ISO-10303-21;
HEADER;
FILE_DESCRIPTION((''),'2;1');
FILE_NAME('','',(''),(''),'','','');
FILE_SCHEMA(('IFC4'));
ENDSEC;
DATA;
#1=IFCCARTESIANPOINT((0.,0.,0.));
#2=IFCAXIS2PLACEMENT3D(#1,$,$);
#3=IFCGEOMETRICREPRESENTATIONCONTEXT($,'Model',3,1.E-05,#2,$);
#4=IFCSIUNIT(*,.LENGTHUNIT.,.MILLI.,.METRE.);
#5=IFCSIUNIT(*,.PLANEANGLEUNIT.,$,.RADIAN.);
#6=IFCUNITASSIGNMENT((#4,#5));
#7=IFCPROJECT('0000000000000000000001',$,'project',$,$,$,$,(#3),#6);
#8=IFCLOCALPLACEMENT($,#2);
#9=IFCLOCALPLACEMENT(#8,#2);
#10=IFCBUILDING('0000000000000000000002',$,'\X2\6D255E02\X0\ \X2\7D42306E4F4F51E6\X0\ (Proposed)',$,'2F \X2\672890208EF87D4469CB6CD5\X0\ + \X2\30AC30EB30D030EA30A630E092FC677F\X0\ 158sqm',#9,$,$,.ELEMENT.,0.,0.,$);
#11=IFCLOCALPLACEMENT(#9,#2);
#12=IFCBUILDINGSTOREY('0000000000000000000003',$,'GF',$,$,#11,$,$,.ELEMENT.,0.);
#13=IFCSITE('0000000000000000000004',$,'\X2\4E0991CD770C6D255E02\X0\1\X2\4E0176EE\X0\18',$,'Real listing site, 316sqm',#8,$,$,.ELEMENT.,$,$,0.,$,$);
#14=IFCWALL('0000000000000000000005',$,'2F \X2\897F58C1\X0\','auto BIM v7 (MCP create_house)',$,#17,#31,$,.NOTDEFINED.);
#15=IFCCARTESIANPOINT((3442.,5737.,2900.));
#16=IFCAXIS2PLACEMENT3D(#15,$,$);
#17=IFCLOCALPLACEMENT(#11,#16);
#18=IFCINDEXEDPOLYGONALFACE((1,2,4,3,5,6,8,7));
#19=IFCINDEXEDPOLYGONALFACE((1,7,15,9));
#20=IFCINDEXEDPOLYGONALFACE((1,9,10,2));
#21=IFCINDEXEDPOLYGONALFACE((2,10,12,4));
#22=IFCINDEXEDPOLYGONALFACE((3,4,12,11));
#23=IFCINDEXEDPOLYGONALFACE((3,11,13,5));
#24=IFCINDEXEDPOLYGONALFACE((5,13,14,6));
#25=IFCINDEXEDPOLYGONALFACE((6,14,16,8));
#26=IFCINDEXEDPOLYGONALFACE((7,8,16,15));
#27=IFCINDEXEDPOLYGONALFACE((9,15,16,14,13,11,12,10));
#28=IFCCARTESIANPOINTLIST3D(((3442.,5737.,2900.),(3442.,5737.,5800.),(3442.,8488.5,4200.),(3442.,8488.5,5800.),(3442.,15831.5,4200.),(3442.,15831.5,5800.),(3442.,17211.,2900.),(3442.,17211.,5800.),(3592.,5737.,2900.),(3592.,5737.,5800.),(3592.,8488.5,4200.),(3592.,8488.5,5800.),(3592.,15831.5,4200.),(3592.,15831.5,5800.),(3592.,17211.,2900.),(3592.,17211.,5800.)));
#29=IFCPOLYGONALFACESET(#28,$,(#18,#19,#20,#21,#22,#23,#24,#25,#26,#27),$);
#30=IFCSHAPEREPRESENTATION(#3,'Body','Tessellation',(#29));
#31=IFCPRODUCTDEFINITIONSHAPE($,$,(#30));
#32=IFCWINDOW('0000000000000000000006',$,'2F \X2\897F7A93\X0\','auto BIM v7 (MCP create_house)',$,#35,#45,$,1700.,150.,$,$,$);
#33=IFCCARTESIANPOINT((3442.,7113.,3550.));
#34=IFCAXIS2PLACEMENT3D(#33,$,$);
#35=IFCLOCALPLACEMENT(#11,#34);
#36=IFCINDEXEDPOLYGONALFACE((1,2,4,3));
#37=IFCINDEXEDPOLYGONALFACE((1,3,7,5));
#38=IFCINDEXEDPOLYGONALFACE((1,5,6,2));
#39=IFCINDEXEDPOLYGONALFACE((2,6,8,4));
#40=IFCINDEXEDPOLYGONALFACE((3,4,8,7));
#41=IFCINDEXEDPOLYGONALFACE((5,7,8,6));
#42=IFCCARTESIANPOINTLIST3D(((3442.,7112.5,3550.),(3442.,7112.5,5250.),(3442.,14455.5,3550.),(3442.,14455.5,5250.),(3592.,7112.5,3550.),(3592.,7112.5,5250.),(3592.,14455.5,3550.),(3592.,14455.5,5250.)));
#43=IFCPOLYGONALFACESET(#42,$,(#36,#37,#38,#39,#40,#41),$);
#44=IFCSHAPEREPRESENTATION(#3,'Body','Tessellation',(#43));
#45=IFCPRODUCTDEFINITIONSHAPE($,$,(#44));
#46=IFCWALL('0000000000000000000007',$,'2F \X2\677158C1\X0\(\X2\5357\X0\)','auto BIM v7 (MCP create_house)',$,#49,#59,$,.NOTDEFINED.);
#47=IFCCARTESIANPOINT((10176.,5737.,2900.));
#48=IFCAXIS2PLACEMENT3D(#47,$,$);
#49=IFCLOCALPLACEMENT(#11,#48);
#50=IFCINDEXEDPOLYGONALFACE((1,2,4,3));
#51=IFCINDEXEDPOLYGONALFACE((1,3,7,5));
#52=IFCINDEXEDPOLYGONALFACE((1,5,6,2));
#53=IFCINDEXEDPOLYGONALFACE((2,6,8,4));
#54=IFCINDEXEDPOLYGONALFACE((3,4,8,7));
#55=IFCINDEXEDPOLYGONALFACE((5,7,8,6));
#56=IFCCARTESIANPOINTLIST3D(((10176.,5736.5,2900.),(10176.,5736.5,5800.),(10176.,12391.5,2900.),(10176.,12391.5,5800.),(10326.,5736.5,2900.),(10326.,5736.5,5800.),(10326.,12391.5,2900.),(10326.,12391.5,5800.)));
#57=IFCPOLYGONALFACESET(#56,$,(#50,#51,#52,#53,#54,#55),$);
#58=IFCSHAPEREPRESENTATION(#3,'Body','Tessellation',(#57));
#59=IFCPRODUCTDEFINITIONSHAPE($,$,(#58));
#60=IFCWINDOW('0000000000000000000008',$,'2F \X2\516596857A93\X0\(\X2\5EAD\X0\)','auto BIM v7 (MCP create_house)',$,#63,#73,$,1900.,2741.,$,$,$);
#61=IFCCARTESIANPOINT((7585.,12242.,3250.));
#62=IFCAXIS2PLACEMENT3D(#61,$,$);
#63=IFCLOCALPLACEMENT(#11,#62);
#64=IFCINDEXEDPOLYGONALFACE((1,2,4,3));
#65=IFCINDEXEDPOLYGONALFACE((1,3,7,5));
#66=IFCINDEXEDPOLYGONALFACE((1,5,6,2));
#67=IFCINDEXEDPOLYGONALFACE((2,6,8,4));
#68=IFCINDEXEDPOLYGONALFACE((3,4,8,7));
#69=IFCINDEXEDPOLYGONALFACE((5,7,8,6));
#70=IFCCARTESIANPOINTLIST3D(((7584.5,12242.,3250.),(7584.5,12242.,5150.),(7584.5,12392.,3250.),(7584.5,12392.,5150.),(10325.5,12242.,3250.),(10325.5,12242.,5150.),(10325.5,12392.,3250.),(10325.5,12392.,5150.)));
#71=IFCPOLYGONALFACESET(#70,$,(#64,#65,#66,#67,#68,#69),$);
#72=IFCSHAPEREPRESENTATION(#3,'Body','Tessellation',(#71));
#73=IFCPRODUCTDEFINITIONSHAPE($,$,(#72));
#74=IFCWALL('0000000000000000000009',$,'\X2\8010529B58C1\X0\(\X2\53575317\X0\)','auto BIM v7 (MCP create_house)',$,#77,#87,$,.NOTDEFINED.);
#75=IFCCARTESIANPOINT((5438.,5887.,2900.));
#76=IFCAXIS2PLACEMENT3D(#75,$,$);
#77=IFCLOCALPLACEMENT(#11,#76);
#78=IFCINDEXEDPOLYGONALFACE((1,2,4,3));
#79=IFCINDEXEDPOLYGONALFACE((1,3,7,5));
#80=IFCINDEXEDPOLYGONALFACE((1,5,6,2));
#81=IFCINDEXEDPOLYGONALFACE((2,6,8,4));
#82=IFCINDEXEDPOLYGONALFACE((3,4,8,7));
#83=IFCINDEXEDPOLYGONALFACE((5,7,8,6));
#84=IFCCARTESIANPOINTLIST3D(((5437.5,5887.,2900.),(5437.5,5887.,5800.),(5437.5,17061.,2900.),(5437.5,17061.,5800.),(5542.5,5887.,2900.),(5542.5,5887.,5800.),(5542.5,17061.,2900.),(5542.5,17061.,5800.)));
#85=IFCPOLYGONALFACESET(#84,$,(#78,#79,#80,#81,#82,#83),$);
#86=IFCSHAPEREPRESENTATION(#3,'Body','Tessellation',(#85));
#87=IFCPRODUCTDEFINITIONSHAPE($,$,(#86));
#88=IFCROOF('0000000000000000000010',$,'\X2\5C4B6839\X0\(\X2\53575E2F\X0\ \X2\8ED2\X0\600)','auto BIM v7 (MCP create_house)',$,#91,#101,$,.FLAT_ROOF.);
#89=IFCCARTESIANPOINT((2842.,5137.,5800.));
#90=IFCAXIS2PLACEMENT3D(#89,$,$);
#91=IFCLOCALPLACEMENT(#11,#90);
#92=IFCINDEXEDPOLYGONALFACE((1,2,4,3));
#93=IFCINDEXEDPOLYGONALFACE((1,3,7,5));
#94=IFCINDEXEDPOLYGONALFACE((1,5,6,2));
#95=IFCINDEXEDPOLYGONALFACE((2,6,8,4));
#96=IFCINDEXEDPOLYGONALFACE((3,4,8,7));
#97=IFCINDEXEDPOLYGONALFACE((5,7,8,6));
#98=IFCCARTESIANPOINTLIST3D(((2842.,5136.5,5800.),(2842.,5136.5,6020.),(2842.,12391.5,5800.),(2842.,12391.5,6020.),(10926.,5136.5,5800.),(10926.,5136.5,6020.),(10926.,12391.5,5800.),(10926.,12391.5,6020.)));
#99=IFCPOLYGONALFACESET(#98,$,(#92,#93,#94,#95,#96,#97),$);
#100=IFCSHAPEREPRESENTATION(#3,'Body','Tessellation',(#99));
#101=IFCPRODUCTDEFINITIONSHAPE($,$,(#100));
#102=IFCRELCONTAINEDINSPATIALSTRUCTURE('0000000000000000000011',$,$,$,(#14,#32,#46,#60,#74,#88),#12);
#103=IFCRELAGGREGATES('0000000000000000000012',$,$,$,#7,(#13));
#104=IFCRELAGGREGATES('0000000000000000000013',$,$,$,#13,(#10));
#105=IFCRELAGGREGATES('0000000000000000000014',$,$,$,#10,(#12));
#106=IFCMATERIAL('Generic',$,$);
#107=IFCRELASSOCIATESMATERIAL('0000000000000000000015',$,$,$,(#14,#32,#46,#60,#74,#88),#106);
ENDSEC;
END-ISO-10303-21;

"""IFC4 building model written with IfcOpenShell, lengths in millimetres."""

from ifc_helpers import new_model, si_unit, frame, frame_2d, origin, place, context, project, spatial, rectangle, extrude, material, element, fill, save


model = new_model("IFC4")

# Units and contexts
model_context = context("Model", 3, precision=1e-05, world=origin())
ifc_project = project(units=[si_unit("LENGTHUNIT", "METRE", prefix="MILLI"), si_unit("PLANEANGLEUNIT", "RADIAN")], contexts=[model_context])

# Site, building, storey
site_placement = place(None, origin())
site = spatial("IfcSite", under=ifc_project, at=site_placement, Name="三重県津市1丁目18", ObjectType="Real listing site, 316sqm", CompositionType="ELEMENT", RefElevation=0.0)
building_placement = place(site_placement, origin())
building = spatial("IfcBuilding", under=site, at=building_placement, Name="津市 終の住処 (Proposed)", ObjectType="2F 木造軸組構法 + ガルバリウム鋼板 158sqm", CompositionType="ELEMENT", ElevationOfRefHeight=0.0, ElevationOfTerrain=0.0)
storey_placement = place(building_placement, origin())
storey = spatial("IfcBuildingStorey", under=building, at=storey_placement, Name="GF", CompositionType="ELEMENT", Elevation=0.0)

# Shared definitions
ifc_material = material(Name="Generic")

# Walls, openings, windows
wall_1_placement = place(storey_placement, frame((3442.0, 5737.0, 2900.0)))
wall_1 = element("IfcWall", 1, at=wall_1_placement, inside=storey, material=ifc_material, Name="2F 西壁", Description="auto BIM v7 (MCP create_house)", PredefinedType="NOTDEFINED", context=model_context, shape_type="SweptSolid", body=[
    extrude(rectangle(XDim=150.0, YDim=11474.0, at=frame_2d((75.0, 5737.0))), frame((3442.0, 5737.0, 2900.0)), (0.0, 0.0, 1.0), 2900.0),
])
opening_1_placement = place(storey_placement, frame((3442.0, 7113.0, 3550.0)))
opening_1 = element("IfcOpeningElement", 2, at=opening_1_placement, cuts=wall_1, PredefinedType="NOTDEFINED", context=model_context, shape_type="SweptSolid", body=[
    extrude(rectangle(XDim=150.0, YDim=7343.0, at=frame_2d((75.0, 3671.0))), frame((3442.0, 7113.0, 3550.0)), (0.0, 0.0, 1.0), 1700.0),
])
window_1_placement = place(storey_placement, frame((3442.0, 7113.0, 3550.0)))
window_1 = element("IfcWindow", 3, at=window_1_placement, inside=storey, material=ifc_material, Name="2F 西窓", Description="auto BIM v7 (MCP create_house)", OverallHeight=1700.0, OverallWidth=150.0, context=model_context, shape_type="SweptSolid", body=[
    extrude(rectangle(XDim=150.0, YDim=7343.0, at=frame_2d((75.0, 3671.0))), frame((3442.0, 7113.0, 3550.0)), (0.0, 0.0, 1.0), 1700.0),
])
fill(opening_1, window_1)
wall_2_placement = place(storey_placement, frame((10176.0, 5737.0, 2900.0)))
wall_2 = element("IfcWall", 4, at=wall_2_placement, inside=storey, material=ifc_material, Name="2F 東壁(南)", Description="auto BIM v7 (MCP create_house)", PredefinedType="NOTDEFINED", context=model_context, shape_type="SweptSolid", body=[
    extrude(rectangle(XDim=150.0, YDim=6655.0, at=frame_2d((75.0, 3327.0))), frame((10176.0, 5737.0, 2900.0)), (0.0, 0.0, 1.0), 2900.0),
])
opening_2_placement = place(storey_placement, frame((7585.0, 12242.0, 3250.0)))
opening_2 = element("IfcOpeningElement", 5, at=opening_2_placement, cuts=wall_2, PredefinedType="NOTDEFINED", context=model_context, shape_type="SweptSolid", body=[
    extrude(rectangle(XDim=2741.0, YDim=150.0, at=frame_2d((1370.0, 75.0))), frame((7585.0, 12242.0, 3250.0)), (0.0, 0.0, 1.0), 1900.0),
])
window_2_placement = place(storey_placement, frame((7585.0, 12242.0, 3250.0)))
window_2 = element("IfcWindow", 6, at=window_2_placement, inside=storey, material=ifc_material, Name="2F 入隅窓(庭)", Description="auto BIM v7 (MCP create_house)", OverallHeight=1900.0, OverallWidth=2741.0, context=model_context, shape_type="SweptSolid", body=[
    extrude(rectangle(XDim=2741.0, YDim=150.0, at=frame_2d((1370.0, 75.0))), frame((7585.0, 12242.0, 3250.0)), (0.0, 0.0, 1.0), 1900.0),
])
fill(opening_2, window_2)

# Wall
wall_3_placement = place(storey_placement, frame((5438.0, 5887.0, 2900.0)))
element("IfcWall", 7, at=wall_3_placement, inside=storey, material=ifc_material, Name="耐力壁(南北)", Description="auto BIM v7 (MCP create_house)", PredefinedType="NOTDEFINED", context=model_context, shape_type="SweptSolid", body=[
    extrude(rectangle(XDim=105.0, YDim=11174.0, at=frame_2d((52.0, 5587.0))), frame((5438.0, 5887.0, 2900.0)), (0.0, 0.0, 1.0), 2900.0),
])

# Roof
for number, where, name in (
    (8, (2842.0, 5137.0, 5800.0), "屋根(南帯 軒600)"),
):
    element("IfcRoof", number, at=place(storey_placement, frame(where)), inside=storey, material=ifc_material, Name=name, Description="auto BIM v7 (MCP create_house)", PredefinedType="FLAT_ROOF", context=model_context, shape_type="SweptSolid", body=[
        extrude(rectangle(XDim=8084.0, YDim=7255.0, at=frame_2d((4042.0, 3627.0))), frame((2842.0, 5137.0, 5800.0)), (0.0, 0.0, 1.0), 220.0),
    ])

save(model, "model.ifc")
